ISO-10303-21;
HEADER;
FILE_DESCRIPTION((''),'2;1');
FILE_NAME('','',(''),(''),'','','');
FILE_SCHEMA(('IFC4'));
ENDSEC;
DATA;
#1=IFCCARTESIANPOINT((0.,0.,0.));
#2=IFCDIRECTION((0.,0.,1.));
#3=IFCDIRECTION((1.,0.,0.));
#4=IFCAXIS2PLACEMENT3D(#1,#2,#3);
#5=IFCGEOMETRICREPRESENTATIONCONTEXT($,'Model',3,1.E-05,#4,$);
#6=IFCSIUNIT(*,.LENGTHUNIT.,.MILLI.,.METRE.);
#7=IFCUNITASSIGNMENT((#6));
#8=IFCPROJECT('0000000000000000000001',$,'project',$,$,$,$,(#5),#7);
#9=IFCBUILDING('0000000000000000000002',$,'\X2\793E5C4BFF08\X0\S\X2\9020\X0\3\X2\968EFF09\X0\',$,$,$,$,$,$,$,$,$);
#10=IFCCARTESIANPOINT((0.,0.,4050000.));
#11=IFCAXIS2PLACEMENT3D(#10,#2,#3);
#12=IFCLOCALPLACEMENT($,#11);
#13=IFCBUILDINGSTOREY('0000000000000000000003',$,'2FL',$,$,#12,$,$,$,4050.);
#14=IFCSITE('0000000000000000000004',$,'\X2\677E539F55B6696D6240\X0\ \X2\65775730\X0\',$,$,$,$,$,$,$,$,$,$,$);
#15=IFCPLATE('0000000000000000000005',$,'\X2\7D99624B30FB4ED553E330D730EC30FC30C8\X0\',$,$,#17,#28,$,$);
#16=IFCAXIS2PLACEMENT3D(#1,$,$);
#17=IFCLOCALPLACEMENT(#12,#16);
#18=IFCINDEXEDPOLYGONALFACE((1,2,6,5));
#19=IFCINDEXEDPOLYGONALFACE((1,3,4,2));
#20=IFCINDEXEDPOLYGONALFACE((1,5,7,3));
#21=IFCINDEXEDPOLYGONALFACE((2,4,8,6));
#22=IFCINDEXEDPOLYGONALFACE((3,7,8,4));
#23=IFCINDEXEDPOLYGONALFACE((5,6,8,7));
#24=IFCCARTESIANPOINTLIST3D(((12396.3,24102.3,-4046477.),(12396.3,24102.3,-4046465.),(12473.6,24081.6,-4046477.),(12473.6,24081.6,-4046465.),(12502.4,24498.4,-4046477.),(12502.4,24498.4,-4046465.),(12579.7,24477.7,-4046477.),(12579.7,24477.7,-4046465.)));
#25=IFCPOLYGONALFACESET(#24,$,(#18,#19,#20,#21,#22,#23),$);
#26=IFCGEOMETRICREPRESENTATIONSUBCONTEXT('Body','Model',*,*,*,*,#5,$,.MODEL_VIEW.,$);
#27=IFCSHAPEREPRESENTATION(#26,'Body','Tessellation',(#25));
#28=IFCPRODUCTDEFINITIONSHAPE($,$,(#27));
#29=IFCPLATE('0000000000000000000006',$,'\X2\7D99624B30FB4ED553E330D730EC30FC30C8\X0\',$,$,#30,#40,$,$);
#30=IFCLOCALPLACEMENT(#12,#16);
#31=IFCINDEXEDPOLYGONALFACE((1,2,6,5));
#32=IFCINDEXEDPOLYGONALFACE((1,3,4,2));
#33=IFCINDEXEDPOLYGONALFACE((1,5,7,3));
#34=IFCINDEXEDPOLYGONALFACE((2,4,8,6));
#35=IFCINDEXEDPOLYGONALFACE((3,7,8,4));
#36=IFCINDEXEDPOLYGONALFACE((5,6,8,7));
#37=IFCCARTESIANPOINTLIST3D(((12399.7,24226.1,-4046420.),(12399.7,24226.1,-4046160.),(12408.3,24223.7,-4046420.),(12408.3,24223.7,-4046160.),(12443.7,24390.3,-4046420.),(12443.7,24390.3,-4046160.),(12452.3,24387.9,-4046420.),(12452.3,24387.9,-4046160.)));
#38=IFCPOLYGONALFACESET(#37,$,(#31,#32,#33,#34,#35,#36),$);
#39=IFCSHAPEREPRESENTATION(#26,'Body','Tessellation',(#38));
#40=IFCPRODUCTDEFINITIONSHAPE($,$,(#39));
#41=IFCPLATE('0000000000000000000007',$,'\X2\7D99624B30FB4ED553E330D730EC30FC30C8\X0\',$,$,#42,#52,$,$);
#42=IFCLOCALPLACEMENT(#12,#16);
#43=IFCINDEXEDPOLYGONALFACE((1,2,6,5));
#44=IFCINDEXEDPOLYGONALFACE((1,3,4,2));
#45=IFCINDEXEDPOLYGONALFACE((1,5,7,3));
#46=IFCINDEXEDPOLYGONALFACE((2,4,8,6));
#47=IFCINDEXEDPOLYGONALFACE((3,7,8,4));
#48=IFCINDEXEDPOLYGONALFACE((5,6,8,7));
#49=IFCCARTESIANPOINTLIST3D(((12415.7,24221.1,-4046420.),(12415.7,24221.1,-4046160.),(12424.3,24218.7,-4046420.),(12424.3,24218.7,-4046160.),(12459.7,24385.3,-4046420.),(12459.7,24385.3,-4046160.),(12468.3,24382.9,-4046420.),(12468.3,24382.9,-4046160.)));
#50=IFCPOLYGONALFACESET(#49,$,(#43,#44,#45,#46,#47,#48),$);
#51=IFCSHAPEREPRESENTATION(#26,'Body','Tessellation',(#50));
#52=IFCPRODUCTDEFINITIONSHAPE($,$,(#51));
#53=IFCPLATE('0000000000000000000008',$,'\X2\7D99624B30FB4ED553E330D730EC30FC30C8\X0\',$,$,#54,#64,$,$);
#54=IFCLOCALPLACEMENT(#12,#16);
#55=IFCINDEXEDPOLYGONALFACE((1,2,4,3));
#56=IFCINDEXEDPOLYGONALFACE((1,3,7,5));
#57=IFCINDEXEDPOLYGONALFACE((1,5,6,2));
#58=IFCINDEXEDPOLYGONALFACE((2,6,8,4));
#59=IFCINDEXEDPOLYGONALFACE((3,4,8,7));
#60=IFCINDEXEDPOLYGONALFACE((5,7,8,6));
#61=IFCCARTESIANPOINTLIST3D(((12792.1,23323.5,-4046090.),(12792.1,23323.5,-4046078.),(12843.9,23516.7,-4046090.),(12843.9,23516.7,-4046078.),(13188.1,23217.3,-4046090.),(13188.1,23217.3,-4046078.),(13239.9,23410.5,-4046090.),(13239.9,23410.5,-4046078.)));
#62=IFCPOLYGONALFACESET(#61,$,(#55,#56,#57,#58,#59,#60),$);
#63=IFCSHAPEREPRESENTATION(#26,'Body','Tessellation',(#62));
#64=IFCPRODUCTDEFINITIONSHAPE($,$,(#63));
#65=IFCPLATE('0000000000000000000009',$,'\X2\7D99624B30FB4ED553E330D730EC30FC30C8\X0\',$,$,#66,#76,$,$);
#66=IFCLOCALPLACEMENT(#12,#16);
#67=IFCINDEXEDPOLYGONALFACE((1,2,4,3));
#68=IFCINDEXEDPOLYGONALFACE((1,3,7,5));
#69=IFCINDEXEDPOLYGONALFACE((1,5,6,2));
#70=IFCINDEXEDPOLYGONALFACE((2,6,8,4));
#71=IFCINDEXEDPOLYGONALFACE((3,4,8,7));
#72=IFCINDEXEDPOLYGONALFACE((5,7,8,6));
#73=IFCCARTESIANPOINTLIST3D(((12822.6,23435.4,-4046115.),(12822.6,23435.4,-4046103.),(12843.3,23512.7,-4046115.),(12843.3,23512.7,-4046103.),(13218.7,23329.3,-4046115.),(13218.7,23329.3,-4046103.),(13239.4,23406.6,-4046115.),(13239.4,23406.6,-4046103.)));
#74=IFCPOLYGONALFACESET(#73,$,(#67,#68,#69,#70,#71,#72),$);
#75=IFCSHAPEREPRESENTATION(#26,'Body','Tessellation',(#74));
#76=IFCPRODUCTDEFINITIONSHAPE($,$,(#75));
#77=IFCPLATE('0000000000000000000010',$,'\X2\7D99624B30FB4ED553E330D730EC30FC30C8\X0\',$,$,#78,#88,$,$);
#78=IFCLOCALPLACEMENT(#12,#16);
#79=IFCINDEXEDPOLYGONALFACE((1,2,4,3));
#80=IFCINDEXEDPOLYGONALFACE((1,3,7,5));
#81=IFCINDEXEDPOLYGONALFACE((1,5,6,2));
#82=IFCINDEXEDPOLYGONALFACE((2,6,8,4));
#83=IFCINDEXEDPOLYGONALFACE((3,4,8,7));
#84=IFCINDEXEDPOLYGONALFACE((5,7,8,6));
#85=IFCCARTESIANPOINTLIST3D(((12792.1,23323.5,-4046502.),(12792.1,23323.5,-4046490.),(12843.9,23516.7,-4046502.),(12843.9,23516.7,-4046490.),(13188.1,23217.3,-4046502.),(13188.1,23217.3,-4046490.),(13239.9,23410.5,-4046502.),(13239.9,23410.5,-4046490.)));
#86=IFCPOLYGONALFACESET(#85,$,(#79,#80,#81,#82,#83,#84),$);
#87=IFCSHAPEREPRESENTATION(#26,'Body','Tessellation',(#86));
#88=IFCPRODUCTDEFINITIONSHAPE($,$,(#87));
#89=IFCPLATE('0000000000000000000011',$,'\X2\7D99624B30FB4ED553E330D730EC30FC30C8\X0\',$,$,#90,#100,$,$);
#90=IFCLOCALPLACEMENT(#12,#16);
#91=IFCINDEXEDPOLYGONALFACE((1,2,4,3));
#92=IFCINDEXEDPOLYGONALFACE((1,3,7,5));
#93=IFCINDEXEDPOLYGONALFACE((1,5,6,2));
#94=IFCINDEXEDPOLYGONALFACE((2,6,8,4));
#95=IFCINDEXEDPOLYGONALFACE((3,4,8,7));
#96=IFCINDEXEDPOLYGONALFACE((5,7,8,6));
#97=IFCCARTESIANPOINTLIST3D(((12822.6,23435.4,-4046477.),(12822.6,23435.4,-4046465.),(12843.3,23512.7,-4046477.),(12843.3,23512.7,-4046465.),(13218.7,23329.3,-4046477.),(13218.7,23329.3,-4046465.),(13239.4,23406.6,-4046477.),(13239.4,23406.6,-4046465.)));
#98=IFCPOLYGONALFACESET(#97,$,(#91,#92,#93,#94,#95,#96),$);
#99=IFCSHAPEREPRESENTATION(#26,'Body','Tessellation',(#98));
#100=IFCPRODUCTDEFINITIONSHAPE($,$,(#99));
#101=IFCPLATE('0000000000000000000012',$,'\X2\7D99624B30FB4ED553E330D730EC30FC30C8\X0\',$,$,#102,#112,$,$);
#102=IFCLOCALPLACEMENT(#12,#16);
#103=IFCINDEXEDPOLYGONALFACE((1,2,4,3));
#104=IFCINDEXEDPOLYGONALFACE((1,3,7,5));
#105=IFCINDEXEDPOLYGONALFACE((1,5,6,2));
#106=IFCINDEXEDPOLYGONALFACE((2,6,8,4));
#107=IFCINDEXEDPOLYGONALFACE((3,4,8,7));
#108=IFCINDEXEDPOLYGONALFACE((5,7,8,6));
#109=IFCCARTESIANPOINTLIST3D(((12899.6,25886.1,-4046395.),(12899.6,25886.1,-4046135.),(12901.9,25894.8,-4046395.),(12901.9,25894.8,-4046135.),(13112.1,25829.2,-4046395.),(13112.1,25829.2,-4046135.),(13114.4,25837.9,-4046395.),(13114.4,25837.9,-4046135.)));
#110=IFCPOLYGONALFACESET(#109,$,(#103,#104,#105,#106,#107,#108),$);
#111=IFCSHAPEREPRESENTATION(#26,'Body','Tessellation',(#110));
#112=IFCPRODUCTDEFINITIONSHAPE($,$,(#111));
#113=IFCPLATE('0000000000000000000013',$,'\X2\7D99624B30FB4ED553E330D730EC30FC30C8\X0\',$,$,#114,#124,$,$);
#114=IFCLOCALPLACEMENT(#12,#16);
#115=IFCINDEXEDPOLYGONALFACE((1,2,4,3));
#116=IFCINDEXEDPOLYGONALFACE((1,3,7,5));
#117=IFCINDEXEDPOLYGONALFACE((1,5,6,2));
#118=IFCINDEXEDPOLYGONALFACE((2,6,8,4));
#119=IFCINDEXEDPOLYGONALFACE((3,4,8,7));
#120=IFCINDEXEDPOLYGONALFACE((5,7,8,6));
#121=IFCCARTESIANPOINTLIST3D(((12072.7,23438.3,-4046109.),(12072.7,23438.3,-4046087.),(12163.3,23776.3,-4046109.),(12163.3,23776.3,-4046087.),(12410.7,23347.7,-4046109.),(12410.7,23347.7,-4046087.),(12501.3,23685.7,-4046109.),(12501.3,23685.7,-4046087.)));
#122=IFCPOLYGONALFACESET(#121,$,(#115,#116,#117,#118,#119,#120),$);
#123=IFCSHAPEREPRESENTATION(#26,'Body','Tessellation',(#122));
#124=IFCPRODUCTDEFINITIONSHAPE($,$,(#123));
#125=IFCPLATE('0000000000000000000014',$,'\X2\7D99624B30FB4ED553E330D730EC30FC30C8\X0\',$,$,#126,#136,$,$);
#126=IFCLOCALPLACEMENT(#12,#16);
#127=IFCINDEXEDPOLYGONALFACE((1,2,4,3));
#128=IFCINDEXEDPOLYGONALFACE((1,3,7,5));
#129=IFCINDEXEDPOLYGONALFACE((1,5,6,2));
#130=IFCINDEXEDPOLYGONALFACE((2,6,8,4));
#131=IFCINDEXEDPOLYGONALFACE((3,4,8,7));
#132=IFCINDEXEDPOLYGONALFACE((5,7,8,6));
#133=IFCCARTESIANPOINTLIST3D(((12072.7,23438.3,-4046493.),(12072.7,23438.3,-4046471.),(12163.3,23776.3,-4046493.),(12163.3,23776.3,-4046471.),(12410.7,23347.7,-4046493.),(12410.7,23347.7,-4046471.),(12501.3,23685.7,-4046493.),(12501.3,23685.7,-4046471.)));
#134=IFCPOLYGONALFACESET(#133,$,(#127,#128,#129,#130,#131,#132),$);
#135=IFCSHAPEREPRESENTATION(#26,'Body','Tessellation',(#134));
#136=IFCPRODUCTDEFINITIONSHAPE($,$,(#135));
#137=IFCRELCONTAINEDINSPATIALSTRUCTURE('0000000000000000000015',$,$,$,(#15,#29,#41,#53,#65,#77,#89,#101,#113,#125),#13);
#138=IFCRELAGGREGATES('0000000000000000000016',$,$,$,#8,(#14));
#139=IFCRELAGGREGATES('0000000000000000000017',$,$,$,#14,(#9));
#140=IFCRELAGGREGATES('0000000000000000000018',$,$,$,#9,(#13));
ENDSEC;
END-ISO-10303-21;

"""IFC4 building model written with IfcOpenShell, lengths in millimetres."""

from ifc_helpers import new_model, si_unit, frame, origin, origin_with_axes, place, context, subcontext, project, spatial, rectangle, extrude, element, save


model = new_model("IFC4")

# Units and contexts
model_context = context("Model", 3, precision=1e-05, world=origin_with_axes())
body_context = subcontext(model_context, "Body", "Model", "MODEL_VIEW")
ifc_project = project(units=[si_unit("LENGTHUNIT", "METRE", prefix="MILLI")], contexts=[model_context])

# Site, building, storey
site = spatial("IfcSite", under=ifc_project, Name="松原営業所 敷地")
building = spatial("IfcBuilding", under=site, Name="社屋（S造3階）")
storey_placement = place(None, frame((0.0, 0.0, 4050000.0), z_axis=(0.0, 0.0, 1.0), x_axis=(1.0, 0.0, 0.0)))
storey = spatial("IfcBuildingStorey", under=building, at=storey_placement, Name="2FL", Elevation=4050.0)

# Plates
for number, where, z_axis, x_axis, name in (
    (1, (12434.9, 24092.0, -4046471.0), (0.258819, 0.965926, 0.0), (-0.965926, 0.258819, 0.0), "継手・仕口プレート"),
):
    element("IfcPlate", number, at=place(storey_placement, frame(where, z_axis=z_axis, x_axis=x_axis)), inside=storey, Name=name, context=body_context, shape_type="SweptSolid", body=[
        extrude(rectangle(XDim=80.0, YDim=12.0), origin(), (0.0, 0.0, 1.0), 410.0),
    ])
for number, where, z_axis, x_axis, name in (
    (2, (12404.0, 24224.9, -4046290.0), (0.258819, 0.965926, 0.0), (-0.965926, 0.258819, 0.0), "継手・仕口プレート"),
    (3, (12420.0, 24219.9, -4046290.0), (0.258819, 0.965926, 0.0), (-0.965926, 0.258819, 0.0), "継手・仕口プレート"),
):
    element("IfcPlate", number, at=place(storey_placement, frame(where, z_axis=z_axis, x_axis=x_axis)), inside=storey, Name=name, context=body_context, shape_type="SweptSolid", body=[
        extrude(rectangle(XDim=9.0, YDim=260.0), origin(), (0.0, 0.0, 1.0), 170.0),
    ])
plate_1_placement = place(storey_placement, frame((12818.0, 23420.1, -4046084.0), z_axis=(0.965926, -0.258819, 0.0), x_axis=(0.258819, 0.965926, 0.0)))
element("IfcPlate", 4, at=plate_1_placement, inside=storey, Name="継手・仕口プレート", context=body_context, shape_type="SweptSolid", body=[
    extrude(rectangle(XDim=200.0, YDim=12.0), origin(), (0.0, 0.0, 1.0), 410.0),
])
plate_2_placement = place(storey_placement, frame((12833.0, 23474.1, -4046109.0), z_axis=(0.965926, -0.258819, 0.0), x_axis=(0.258819, 0.965926, 0.0)))
element("IfcPlate", 5, at=plate_2_placement, inside=storey, Name="継手・仕口プレート", context=body_context, shape_type="SweptSolid", body=[
    extrude(rectangle(XDim=80.0, YDim=12.0), origin(), (0.0, 0.0, 1.0), 410.0),
])
plate_3_placement = place(storey_placement, frame((12818.0, 23420.1, -4046496.0), z_axis=(0.965926, -0.258819, 0.0), x_axis=(0.258819, 0.965926, 0.0)))
element("IfcPlate", 6, at=plate_3_placement, inside=storey, Name="継手・仕口プレート", context=body_context, shape_type="SweptSolid", body=[
    extrude(rectangle(XDim=200.0, YDim=12.0), origin(), (0.0, 0.0, 1.0), 410.0),
])
plate_4_placement = place(storey_placement, frame((12833.0, 23474.1, -4046471.0), z_axis=(0.965926, -0.258819, 0.0), x_axis=(0.258819, 0.965926, 0.0)))
element("IfcPlate", 7, at=plate_4_placement, inside=storey, Name="継手・仕口プレート", context=body_context, shape_type="SweptSolid", body=[
    extrude(rectangle(XDim=80.0, YDim=12.0), origin(), (0.0, 0.0, 1.0), 410.0),
])
plate_5_placement = place(storey_placement, frame((12900.7, 25890.5, -4046265.0), z_axis=(0.965926, -0.258819, 0.0), x_axis=(0.258819, 0.965926, 0.0)))
element("IfcPlate", 8, at=plate_5_placement, inside=storey, Name="継手・仕口プレート", context=body_context, shape_type="SweptSolid", body=[
    extrude(rectangle(XDim=9.0, YDim=260.0), origin(), (0.0, 0.0, 1.0), 220.0),
])
for number, where, z_axis, x_axis, name in (
    (9, (12118.0, 23607.3, -4046098.0), (0.965926, -0.258819, 0.0), (0.258819, 0.965926, 0.0), "継手・仕口プレート"),
    (10, (12118.0, 23607.3, -4046482.0), (0.965926, -0.258819, 0.0), (0.258819, 0.965926, 0.0), "継手・仕口プレート"),
):
    element("IfcPlate", number, at=place(storey_placement, frame(where, z_axis=z_axis, x_axis=x_axis)), inside=storey, Name=name, context=body_context, shape_type="SweptSolid", body=[
        extrude(rectangle(XDim=350.0, YDim=22.0), origin(), (0.0, 0.0, 1.0), 350.0),
    ])

save(model, "model.ifc")
